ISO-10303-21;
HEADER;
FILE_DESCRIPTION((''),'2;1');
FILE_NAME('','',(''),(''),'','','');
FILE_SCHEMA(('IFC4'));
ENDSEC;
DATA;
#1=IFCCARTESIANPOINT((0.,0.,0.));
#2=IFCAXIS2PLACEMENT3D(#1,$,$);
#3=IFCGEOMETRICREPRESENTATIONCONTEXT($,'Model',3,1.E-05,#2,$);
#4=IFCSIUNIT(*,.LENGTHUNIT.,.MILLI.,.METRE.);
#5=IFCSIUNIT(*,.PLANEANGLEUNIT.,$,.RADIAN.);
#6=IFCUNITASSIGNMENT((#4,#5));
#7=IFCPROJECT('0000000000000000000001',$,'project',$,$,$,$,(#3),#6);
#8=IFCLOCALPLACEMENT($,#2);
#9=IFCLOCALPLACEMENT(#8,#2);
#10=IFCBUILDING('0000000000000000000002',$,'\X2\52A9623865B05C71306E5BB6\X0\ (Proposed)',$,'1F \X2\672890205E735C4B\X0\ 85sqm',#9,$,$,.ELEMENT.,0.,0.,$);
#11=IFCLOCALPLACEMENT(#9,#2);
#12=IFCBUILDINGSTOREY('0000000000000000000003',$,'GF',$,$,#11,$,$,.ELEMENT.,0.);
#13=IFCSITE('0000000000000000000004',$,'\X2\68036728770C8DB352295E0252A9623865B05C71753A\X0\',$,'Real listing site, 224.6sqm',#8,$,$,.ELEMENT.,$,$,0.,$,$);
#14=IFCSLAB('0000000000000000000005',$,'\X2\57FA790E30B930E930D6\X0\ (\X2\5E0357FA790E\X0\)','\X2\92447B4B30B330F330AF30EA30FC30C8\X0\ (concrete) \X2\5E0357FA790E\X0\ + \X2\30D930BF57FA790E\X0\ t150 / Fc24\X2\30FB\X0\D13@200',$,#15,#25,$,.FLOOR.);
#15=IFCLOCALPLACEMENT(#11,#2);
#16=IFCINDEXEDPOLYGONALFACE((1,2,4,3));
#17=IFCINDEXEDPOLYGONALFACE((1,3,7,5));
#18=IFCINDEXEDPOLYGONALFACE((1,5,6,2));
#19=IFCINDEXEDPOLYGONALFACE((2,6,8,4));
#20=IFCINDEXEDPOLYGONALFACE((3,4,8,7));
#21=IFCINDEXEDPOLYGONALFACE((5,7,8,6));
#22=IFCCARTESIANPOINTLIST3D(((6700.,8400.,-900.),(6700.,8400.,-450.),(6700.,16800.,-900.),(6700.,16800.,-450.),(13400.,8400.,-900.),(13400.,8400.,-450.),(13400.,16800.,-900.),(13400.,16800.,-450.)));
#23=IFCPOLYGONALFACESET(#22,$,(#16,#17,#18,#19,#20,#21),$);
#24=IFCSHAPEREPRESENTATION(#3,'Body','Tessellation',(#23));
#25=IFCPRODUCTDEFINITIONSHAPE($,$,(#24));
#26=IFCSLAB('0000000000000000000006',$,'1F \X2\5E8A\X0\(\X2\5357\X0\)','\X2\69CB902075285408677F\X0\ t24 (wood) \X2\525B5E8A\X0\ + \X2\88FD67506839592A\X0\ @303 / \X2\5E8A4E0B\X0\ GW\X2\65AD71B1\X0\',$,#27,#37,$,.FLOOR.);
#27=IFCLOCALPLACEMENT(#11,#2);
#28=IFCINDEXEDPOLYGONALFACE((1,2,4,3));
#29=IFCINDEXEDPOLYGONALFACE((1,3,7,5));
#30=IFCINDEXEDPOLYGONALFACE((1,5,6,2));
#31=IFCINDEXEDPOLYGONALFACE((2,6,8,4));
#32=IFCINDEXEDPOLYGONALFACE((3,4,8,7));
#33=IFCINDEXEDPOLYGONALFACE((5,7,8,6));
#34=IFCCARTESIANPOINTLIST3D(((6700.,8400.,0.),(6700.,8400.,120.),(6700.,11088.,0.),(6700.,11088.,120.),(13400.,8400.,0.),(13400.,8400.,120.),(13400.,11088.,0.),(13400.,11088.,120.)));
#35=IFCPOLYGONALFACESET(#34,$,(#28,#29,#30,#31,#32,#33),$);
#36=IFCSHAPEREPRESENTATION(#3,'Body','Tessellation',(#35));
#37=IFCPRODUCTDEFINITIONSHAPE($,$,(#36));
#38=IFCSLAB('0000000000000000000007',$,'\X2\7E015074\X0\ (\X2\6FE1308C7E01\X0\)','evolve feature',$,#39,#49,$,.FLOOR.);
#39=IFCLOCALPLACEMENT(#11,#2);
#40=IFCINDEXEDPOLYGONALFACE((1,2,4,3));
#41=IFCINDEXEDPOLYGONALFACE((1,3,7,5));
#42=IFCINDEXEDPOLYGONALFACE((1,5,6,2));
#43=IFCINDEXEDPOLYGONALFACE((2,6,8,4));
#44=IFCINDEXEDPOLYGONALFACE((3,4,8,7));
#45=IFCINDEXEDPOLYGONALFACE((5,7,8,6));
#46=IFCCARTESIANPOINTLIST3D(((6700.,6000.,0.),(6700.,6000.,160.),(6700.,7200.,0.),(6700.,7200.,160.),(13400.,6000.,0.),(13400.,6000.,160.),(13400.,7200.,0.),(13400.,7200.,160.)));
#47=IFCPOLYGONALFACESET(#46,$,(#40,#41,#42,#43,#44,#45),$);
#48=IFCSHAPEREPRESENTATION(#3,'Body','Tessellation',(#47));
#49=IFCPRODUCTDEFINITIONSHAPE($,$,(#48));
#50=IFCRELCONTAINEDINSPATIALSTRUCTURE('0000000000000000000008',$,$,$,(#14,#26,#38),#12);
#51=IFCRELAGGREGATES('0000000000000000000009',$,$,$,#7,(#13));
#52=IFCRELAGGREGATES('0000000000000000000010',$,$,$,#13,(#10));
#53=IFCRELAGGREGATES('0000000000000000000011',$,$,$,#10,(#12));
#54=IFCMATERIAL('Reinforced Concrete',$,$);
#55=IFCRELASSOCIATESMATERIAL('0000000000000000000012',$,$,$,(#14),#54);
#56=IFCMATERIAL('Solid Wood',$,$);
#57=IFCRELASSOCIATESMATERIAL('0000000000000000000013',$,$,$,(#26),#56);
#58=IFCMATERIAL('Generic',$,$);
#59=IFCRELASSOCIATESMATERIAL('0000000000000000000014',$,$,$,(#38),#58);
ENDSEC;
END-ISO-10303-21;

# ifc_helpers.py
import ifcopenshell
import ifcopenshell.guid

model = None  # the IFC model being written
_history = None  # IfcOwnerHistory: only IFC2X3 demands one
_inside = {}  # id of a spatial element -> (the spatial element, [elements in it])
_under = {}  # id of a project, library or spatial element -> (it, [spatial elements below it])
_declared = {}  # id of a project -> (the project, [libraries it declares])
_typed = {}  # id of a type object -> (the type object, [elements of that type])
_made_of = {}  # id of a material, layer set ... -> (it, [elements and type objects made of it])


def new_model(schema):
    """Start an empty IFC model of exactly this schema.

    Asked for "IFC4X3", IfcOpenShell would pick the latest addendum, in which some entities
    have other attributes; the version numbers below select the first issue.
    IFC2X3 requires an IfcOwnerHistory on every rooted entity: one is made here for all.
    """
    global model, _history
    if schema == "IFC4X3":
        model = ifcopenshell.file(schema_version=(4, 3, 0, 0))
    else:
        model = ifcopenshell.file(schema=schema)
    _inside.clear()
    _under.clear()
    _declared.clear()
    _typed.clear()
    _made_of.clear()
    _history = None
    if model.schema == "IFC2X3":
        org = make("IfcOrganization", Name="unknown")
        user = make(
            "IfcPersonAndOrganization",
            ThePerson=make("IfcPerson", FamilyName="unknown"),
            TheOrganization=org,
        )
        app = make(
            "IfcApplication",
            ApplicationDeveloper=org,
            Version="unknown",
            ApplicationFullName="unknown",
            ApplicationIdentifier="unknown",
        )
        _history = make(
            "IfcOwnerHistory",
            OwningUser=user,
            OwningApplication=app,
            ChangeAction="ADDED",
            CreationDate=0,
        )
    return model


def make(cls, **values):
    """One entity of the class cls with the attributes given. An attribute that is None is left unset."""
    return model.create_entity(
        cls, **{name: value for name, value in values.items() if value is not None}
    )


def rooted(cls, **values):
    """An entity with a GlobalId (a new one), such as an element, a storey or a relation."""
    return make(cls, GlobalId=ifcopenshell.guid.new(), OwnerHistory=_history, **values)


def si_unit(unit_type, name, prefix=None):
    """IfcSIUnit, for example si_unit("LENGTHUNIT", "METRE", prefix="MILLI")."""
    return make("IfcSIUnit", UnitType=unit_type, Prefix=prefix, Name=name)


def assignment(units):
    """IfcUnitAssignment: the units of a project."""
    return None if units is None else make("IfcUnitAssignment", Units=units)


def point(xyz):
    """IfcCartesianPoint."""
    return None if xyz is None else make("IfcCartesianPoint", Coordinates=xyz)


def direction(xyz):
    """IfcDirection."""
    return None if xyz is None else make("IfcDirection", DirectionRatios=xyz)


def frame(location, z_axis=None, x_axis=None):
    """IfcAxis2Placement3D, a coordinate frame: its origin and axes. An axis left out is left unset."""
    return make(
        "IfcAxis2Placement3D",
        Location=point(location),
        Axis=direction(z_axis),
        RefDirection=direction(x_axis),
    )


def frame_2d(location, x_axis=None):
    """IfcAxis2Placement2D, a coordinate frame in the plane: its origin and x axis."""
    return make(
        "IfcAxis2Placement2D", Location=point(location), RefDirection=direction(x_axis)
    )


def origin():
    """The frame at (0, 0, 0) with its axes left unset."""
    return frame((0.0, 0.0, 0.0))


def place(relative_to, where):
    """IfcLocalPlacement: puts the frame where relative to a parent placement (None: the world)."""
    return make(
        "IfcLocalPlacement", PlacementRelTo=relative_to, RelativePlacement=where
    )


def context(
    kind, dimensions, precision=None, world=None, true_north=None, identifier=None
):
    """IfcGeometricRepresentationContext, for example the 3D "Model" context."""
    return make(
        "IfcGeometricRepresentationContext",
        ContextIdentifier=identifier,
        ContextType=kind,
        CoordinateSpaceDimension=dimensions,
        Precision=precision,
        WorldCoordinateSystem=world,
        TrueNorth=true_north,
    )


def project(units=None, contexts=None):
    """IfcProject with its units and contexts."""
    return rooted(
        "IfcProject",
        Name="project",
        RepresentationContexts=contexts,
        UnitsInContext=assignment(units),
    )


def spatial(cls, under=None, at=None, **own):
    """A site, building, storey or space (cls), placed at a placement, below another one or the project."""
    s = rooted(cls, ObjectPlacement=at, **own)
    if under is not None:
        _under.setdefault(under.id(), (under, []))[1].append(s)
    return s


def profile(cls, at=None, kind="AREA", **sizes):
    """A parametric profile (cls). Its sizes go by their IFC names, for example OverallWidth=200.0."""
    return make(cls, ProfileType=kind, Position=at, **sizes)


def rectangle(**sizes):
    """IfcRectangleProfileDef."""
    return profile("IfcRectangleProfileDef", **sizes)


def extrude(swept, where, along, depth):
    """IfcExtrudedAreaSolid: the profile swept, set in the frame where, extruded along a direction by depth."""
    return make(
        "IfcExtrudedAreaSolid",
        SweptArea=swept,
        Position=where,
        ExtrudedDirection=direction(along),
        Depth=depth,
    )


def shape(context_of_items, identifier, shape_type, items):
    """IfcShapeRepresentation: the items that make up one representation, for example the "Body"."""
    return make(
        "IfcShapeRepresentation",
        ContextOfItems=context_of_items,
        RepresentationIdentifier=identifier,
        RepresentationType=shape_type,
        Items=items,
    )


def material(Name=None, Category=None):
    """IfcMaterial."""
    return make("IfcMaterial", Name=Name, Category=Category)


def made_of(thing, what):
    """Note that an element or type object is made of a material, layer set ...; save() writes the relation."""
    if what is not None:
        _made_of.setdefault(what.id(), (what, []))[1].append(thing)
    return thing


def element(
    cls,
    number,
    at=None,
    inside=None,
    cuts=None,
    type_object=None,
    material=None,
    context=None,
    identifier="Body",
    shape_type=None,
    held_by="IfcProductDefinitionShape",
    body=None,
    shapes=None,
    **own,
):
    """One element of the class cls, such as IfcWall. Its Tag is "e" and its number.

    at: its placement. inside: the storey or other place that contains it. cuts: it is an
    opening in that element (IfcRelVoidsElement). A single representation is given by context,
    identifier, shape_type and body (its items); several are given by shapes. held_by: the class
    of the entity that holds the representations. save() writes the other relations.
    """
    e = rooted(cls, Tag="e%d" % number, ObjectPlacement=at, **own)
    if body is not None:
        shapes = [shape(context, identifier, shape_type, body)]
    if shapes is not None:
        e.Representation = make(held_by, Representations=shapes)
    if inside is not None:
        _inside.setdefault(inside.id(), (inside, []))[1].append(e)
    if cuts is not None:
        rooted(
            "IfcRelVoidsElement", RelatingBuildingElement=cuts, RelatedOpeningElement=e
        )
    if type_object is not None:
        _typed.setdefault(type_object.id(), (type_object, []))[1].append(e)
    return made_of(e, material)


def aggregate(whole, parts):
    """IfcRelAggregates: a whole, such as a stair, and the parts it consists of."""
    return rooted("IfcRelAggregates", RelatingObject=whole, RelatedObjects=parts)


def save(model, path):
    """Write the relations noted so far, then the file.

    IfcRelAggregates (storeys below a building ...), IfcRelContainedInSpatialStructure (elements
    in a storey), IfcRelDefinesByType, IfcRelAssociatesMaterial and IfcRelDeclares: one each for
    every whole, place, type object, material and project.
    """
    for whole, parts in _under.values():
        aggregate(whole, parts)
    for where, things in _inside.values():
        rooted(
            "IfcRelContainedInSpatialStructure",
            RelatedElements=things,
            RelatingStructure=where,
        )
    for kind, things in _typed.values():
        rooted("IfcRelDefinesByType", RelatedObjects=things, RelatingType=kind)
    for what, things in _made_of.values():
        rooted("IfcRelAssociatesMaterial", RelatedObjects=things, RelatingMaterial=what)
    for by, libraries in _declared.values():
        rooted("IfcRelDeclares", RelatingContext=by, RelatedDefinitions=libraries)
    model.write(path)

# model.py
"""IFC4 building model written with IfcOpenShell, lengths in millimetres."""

from ifc_helpers import new_model, si_unit, frame, frame_2d, origin, place, context, project, spatial, rectangle, extrude, material, element, save


model = new_model("IFC4")

# Units and contexts
model_context = context("Model", 3, precision=1e-05, world=origin())
ifc_project = project(units=[si_unit("LENGTHUNIT", "METRE", prefix="MILLI"), si_unit("PLANEANGLEUNIT", "RADIAN")], contexts=[model_context])

# Site, building, storey
site_placement = place(None, origin())
site = spatial("IfcSite", under=ifc_project, at=site_placement, Name="栃木県足利市助戸新山町", ObjectType="Real listing site, 224.6sqm", CompositionType="ELEMENT", RefElevation=0.0)
building_placement = place(site_placement, origin())
building = spatial("IfcBuilding", under=site, at=building_placement, Name="助戸新山の家 (Proposed)", ObjectType="1F 木造平屋 85sqm", CompositionType="ELEMENT", ElevationOfRefHeight=0.0, ElevationOfTerrain=0.0)
storey_placement = place(building_placement, origin())
storey = spatial("IfcBuildingStorey", under=building, at=storey_placement, Name="GF", CompositionType="ELEMENT", Elevation=0.0)

# Slabs
ifc_material_1 = material(Name="Reinforced Concrete")
slab_1_placement = place(storey_placement, frame((3350.0, 4200.0, -450.0)))
element("IfcSlab", 1, at=slab_1_placement, inside=storey, material=ifc_material_1, Name="基礎スラブ (布基礎)", Description="鉄筋コンクリート (concrete) 布基礎 + ベタ基礎 t150 / Fc24・D13@200", PredefinedType="FLOOR", context=model_context, shape_type="SweptSolid", body=[
    extrude(rectangle(XDim=6700.0, YDim=8400.0, at=frame_2d((3350.0, 4200.0))), frame((3350.0, 4200.0, -450.0)), (0.0, 0.0, 1.0), 450.0),
])
ifc_material_2 = material(Name="Solid Wood")
slab_2_placement = place(storey_placement, frame((3350.0, 4200.0, 0.0)))
element("IfcSlab", 2, at=slab_2_placement, inside=storey, material=ifc_material_2, Name="1F 床(南)", Description="構造用合板 t24 (wood) 剛床 + 製材根太 @303 / 床下 GW断熱", PredefinedType="FLOOR", context=model_context, shape_type="SweptSolid", body=[
    extrude(rectangle(XDim=6700.0, YDim=2688.0, at=frame_2d((3350.0, 1344.0))), frame((3350.0, 4200.0, 0.0)), (0.0, 0.0, 1.0), 120.0),
])
ifc_material_3 = material(Name="Generic")
slab_3_placement = place(storey_placement, frame((3350.0, 3000.0, 0.0)))
element("IfcSlab", 3, at=slab_3_placement, inside=storey, material=ifc_material_3, Name="縁側 (濡れ縁)", Description="evolve feature", PredefinedType="FLOOR", context=model_context, shape_type="SweptSolid", body=[
    extrude(rectangle(XDim=6700.0, YDim=1200.0, at=frame_2d((3350.0, 600.0))), frame((3350.0, 3000.0, 0.0)), (0.0, 0.0, 1.0), 160.0),
])

save(model, "model.ifc")
